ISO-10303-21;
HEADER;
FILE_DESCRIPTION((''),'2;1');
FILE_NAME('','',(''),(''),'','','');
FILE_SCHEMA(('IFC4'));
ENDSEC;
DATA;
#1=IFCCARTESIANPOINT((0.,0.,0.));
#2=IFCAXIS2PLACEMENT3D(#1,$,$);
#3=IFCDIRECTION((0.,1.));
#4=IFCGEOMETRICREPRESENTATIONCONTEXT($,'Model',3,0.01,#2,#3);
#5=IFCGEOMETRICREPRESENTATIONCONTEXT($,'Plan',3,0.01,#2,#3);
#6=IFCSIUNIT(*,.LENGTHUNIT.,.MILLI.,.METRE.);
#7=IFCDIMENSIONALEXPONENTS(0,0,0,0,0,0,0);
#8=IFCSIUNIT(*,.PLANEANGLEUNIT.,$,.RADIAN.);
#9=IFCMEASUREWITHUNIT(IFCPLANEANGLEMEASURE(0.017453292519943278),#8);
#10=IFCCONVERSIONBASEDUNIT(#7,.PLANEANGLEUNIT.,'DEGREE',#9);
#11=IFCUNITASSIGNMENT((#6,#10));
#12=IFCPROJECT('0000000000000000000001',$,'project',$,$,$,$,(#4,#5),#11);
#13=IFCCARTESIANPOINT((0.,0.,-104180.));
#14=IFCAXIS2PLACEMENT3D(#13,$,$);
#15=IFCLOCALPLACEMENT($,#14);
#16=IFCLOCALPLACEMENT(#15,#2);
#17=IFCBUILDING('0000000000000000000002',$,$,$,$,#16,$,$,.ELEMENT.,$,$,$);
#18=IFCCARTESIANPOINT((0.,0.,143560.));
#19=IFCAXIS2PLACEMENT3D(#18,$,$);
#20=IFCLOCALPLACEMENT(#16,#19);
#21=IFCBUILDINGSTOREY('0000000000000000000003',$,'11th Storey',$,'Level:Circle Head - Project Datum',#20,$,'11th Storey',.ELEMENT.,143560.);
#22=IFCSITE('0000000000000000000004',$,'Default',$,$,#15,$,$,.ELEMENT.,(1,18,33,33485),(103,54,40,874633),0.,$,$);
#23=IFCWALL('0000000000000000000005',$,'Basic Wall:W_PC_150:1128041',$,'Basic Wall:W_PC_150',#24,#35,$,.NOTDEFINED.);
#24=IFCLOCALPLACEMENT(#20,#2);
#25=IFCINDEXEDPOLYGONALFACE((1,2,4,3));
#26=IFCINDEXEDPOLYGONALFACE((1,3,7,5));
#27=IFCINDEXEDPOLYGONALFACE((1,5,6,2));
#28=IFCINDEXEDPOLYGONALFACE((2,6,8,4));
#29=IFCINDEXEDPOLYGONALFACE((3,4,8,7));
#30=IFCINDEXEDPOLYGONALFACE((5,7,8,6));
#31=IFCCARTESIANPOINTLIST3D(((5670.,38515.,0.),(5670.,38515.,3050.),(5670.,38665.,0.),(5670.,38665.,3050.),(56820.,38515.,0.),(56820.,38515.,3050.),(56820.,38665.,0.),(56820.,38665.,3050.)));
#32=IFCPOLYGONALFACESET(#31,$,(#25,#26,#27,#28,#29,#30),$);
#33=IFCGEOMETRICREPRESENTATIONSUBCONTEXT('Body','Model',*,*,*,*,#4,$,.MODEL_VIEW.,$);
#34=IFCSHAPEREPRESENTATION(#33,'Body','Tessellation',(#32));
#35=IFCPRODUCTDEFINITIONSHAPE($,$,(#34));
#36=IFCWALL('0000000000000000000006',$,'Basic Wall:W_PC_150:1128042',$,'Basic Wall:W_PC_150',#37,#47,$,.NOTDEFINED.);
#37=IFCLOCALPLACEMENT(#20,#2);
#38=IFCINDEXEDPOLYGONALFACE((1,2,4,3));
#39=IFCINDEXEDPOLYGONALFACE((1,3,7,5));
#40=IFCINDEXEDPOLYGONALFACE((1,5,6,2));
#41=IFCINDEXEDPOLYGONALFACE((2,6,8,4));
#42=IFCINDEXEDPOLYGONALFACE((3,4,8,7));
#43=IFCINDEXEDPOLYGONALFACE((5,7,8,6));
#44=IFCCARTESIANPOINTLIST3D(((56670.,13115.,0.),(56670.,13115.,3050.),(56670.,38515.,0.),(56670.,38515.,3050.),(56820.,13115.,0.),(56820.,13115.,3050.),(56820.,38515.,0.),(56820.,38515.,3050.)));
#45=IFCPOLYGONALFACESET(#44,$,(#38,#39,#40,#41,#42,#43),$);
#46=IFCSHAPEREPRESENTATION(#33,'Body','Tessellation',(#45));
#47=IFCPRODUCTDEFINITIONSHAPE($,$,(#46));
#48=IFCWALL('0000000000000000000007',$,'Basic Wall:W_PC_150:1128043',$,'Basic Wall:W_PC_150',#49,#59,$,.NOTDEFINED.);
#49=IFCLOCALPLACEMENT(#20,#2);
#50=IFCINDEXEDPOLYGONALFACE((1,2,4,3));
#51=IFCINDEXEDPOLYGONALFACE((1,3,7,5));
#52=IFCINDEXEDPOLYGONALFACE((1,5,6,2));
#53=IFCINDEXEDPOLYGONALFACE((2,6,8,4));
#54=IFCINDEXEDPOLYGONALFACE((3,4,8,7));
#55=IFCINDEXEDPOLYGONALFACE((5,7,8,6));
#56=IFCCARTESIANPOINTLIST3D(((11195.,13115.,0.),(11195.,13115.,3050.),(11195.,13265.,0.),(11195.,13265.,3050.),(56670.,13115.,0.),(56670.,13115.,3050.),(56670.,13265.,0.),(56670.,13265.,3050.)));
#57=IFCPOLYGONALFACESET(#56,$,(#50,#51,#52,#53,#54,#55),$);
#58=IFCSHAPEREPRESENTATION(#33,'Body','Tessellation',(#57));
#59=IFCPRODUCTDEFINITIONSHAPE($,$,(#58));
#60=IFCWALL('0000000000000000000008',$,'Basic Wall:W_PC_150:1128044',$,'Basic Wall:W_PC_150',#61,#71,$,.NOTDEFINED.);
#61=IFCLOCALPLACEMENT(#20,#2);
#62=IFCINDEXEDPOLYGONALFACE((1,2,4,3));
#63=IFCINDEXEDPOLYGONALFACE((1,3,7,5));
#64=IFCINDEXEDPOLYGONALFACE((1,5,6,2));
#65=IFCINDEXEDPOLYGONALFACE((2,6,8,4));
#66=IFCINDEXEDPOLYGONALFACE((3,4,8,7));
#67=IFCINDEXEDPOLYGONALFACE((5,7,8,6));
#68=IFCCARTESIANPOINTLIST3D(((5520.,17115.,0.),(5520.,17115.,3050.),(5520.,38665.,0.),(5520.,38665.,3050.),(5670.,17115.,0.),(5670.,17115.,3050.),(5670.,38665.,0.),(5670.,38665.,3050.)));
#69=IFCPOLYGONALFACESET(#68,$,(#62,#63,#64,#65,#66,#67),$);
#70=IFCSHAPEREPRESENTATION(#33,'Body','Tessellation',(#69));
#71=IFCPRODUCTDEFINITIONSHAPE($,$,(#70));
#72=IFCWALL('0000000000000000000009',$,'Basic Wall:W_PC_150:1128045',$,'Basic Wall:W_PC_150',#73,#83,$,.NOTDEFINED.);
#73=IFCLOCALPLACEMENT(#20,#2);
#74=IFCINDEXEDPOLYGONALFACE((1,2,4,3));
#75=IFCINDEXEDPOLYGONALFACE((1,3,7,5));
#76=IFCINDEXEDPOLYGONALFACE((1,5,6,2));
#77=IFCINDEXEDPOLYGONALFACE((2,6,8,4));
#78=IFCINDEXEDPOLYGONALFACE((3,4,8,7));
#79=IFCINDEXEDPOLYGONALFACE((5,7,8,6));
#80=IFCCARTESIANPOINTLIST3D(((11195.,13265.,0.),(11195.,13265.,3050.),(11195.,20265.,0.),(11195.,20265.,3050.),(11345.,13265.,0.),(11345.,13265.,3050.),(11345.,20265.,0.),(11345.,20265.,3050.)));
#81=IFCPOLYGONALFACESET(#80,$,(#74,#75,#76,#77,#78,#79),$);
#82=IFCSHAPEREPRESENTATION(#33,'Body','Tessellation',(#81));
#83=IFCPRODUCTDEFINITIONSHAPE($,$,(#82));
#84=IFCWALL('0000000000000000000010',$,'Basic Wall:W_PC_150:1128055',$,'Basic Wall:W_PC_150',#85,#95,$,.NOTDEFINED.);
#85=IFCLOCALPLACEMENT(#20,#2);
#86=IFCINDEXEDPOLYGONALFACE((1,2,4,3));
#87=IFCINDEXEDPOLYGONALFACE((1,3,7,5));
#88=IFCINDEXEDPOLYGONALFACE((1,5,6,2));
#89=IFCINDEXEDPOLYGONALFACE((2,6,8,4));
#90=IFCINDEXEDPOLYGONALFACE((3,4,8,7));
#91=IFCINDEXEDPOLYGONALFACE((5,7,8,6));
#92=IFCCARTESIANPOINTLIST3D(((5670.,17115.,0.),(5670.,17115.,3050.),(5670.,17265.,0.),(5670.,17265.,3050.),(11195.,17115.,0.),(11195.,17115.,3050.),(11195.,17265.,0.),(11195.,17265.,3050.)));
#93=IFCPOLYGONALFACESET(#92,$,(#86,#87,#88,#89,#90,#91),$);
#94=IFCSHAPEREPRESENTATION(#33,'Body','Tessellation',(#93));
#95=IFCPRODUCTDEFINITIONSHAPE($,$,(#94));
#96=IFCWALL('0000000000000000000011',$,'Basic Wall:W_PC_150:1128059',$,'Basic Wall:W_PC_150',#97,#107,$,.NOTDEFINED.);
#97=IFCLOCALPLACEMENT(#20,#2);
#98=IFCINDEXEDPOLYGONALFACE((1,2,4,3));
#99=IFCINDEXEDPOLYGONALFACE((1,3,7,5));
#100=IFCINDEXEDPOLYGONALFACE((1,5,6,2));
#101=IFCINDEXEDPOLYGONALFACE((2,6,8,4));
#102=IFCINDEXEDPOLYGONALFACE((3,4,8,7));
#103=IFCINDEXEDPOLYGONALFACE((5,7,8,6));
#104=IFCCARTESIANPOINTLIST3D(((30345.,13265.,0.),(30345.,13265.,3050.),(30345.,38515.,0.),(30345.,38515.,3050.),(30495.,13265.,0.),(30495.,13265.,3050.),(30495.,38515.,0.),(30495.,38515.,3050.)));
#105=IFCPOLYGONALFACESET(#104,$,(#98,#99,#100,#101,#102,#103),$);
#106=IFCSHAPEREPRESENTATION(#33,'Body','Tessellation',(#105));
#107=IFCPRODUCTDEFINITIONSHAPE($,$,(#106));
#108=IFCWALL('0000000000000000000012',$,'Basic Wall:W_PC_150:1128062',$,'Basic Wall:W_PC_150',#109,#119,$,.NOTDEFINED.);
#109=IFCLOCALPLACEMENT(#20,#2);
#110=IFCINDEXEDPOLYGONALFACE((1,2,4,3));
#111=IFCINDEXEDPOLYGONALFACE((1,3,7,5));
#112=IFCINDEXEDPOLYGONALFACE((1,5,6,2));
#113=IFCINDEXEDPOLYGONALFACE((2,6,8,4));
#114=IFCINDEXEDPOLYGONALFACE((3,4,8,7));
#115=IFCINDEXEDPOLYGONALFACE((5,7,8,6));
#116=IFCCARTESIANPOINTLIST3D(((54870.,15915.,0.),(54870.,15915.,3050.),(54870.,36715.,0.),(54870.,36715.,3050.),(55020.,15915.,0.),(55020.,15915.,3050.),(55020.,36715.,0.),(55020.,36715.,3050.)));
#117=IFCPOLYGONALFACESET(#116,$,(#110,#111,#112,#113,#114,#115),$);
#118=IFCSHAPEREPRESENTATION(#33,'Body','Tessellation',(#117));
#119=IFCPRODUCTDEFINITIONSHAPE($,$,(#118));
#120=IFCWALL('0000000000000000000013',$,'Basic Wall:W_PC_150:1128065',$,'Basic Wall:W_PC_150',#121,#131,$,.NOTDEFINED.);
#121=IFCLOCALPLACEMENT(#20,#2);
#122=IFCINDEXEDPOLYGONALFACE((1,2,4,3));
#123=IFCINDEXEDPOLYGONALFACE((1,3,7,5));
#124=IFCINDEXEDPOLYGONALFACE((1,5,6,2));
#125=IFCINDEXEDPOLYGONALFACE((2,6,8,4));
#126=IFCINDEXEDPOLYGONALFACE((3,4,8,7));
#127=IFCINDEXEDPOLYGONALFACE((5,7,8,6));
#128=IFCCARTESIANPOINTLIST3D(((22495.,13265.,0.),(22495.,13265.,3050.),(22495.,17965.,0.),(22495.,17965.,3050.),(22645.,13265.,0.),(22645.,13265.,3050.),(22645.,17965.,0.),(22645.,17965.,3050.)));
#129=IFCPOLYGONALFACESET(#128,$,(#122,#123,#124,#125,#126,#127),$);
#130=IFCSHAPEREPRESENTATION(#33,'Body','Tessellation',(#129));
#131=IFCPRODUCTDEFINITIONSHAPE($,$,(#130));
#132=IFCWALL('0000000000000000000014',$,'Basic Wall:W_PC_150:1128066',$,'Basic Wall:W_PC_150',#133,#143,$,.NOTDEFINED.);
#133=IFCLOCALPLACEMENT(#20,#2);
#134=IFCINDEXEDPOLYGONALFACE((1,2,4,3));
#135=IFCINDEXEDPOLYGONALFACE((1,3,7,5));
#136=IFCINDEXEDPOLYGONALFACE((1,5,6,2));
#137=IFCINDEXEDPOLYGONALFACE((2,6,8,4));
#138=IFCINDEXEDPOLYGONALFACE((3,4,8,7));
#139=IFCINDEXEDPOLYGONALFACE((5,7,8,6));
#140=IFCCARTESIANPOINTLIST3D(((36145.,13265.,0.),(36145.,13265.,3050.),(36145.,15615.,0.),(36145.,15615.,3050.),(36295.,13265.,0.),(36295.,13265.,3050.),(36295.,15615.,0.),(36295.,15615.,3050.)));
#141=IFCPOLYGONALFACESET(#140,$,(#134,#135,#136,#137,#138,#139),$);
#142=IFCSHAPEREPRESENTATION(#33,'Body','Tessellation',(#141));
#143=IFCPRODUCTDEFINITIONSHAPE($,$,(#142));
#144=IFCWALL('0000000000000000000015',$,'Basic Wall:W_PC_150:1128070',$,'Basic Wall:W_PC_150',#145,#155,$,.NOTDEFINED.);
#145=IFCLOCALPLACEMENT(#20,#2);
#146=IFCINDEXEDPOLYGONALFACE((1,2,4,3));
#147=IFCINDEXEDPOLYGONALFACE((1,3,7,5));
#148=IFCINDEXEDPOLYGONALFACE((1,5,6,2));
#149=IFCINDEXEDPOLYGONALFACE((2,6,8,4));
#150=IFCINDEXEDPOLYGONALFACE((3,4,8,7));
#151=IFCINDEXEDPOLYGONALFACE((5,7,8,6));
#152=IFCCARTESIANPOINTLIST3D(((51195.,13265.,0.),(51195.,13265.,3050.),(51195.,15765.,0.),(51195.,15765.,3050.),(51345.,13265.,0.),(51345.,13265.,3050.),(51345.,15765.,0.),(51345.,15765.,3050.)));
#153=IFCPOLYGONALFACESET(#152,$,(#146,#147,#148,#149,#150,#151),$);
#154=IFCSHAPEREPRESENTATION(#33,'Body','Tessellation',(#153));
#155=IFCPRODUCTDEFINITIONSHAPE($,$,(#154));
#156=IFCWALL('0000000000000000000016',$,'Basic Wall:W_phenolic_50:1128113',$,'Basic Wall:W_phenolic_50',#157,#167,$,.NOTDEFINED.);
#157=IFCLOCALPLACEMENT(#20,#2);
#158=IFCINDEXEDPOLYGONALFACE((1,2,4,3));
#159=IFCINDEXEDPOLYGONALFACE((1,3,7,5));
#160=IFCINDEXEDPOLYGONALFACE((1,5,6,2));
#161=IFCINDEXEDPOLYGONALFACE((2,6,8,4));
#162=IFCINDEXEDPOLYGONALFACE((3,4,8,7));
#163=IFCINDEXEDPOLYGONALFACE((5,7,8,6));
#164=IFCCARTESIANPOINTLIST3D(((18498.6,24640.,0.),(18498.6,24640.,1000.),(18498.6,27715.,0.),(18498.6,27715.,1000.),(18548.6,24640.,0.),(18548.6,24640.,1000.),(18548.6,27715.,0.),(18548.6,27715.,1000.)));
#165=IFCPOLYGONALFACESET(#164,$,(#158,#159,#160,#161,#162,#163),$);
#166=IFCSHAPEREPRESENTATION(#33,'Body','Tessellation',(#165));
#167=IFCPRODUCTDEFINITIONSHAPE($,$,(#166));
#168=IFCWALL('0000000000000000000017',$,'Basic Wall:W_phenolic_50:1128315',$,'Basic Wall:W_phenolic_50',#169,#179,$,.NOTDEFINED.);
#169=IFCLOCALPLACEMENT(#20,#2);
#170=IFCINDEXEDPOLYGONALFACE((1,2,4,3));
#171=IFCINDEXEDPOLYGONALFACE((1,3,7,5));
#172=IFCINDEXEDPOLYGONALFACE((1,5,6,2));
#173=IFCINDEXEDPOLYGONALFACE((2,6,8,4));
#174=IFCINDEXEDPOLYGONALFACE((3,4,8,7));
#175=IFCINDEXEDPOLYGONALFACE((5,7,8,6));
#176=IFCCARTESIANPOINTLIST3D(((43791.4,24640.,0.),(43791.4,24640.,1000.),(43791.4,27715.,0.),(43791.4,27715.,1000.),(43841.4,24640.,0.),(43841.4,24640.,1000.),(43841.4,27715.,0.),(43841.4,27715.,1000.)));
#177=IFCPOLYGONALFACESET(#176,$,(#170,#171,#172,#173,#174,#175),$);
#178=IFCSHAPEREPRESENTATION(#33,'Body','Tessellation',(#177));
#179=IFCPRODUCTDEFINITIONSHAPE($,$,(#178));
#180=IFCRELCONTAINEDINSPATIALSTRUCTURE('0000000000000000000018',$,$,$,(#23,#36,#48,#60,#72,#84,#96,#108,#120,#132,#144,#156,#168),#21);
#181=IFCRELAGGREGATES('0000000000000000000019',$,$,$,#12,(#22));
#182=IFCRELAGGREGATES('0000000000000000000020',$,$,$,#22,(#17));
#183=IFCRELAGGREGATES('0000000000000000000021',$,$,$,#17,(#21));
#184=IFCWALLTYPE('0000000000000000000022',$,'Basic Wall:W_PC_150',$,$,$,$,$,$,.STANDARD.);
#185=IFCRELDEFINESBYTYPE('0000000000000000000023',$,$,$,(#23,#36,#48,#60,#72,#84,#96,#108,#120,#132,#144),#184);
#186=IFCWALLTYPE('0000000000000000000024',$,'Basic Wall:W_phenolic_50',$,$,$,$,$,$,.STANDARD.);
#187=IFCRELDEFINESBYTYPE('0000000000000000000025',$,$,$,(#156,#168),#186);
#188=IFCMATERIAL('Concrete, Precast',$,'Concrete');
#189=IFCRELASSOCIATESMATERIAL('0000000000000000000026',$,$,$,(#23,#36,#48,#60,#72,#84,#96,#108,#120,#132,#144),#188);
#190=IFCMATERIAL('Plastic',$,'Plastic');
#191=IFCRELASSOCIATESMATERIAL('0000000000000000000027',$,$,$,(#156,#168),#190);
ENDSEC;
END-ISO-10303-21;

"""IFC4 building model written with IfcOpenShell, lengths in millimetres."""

from ifc_helpers import new_model, entity, si_unit, converted_unit, direction, frame, origin, place, context, subcontext, project, spatial, indexed_curve, outline, extrude, material, type_object, element, save


model = new_model("IFC4")

# Units and contexts
model_context = context("Model", 3, precision=0.01, world=origin(), true_north=direction((0.0, 1.0)))
plan_context = context("Plan", 3, precision=0.01, world=origin(), true_north=direction((0.0, 1.0)))
body_context = subcontext(model_context, "Body", "Model", "MODEL_VIEW")
ifc_project = project(units=[si_unit("LENGTHUNIT", "METRE", prefix="MILLI"), converted_unit("PLANEANGLEUNIT", "DEGREE", entity("IfcPlaneAngleMeasure", 0.017453292519943278), si_unit("PLANEANGLEUNIT", "RADIAN"), dimensions=[0, 0, 0, 0, 0, 0, 0])], contexts=[model_context, plan_context])

# Site, building, storey
site_placement = place(None, frame((0.0, 0.0, -104180.0)))
site = spatial("IfcSite", under=ifc_project, at=site_placement, Name="Default", CompositionType="ELEMENT", RefLatitude=(1, 18, 33, 33485), RefLongitude=(103, 54, 40, 874633), RefElevation=0.0)
building_placement = place(site_placement, origin())
building = spatial("IfcBuilding", under=site, at=building_placement, CompositionType="ELEMENT")
storey_placement = place(building_placement, frame((0.0, 0.0, 143560.0)))
storey = spatial("IfcBuildingStorey", under=building, at=storey_placement, Name="11th Storey", ObjectType="Level:Circle Head - Project Datum", LongName="11th Storey", CompositionType="ELEMENT", Elevation=143560.0)

# Shared definitions
ifc_material_1 = material(Name="Concrete, Precast", Category="Concrete")

# Walls
wall_type_1 = type_object("IfcWallType", Name="Basic Wall:W_PC_150", PredefinedType="STANDARD")
wall_1_placement = place(storey_placement, frame((56820.0, 38590.0, 0.0), z_axis=(0.0, 0.0, 1.0), x_axis=(-1.0, 0.0, 0.0)))
element("IfcWall", 1, at=wall_1_placement, inside=storey, type_object=wall_type_1, material=ifc_material_1, Name="Basic Wall:W_PC_150:1128041", ObjectType="Basic Wall:W_PC_150", PredefinedType="NOTDEFINED", context=body_context, shape_type="SweptSolid", body=[
    extrude(outline(indexed_curve([(51150.0, 75.0), (0.0, 75.0), (0.0, -75.0), (51150.0, -75.0), (51150.0, 75.0)], self_intersect=False)), origin(), (0.0, 0.0, 1.0), 3050.0),
])
wall_2_placement = place(storey_placement, frame((56745.0, 13115.0, 0.0), z_axis=(0.0, 0.0, 1.0), x_axis=(0.0, 1.0, 0.0)))
element("IfcWall", 2, at=wall_2_placement, inside=storey, type_object=wall_type_1, material=ifc_material_1, Name="Basic Wall:W_PC_150:1128042", ObjectType="Basic Wall:W_PC_150", PredefinedType="NOTDEFINED", context=body_context, shape_type="SweptSolid", body=[
    extrude(outline(indexed_curve([(25400.0, 75.0), (0.0, 75.0), (0.0, -75.0), (25400.0, -75.0), (25400.0, 75.0)], self_intersect=False)), origin(), (0.0, 0.0, 1.0), 3050.0),
])
wall_3_placement = place(storey_placement, frame((11195.0, 13190.0, 0.0)))
element("IfcWall", 3, at=wall_3_placement, inside=storey, type_object=wall_type_1, material=ifc_material_1, Name="Basic Wall:W_PC_150:1128043", ObjectType="Basic Wall:W_PC_150", PredefinedType="NOTDEFINED", context=body_context, shape_type="SweptSolid", body=[
    extrude(outline(indexed_curve([(45475.0, 75.0), (0.0, 75.0), (0.0, -75.0), (45475.0, -75.0), (45475.0, 75.0)], self_intersect=False)), origin(), (0.0, 0.0, 1.0), 3050.0),
])
wall_4_placement = place(storey_placement, frame((5595.0, 38665.0, 0.0), z_axis=(0.0, 0.0, 1.0), x_axis=(0.0, -1.0, 0.0)))
element("IfcWall", 4, at=wall_4_placement, inside=storey, type_object=wall_type_1, material=ifc_material_1, Name="Basic Wall:W_PC_150:1128044", ObjectType="Basic Wall:W_PC_150", PredefinedType="NOTDEFINED", context=body_context, shape_type="SweptSolid", body=[
    extrude(outline(indexed_curve([(21550.0, 75.0), (0.0, 75.0), (0.0, -75.0), (21550.0, -75.0), (21550.0, 75.0)], self_intersect=False)), origin(), (0.0, 0.0, 1.0), 3050.0),
])
wall_5_placement = place(storey_placement, frame((11270.0, 20265.0, 0.0), z_axis=(0.0, 0.0, 1.0), x_axis=(0.0, -1.0, 0.0)))
element("IfcWall", 5, at=wall_5_placement, inside=storey, type_object=wall_type_1, material=ifc_material_1, Name="Basic Wall:W_PC_150:1128045", ObjectType="Basic Wall:W_PC_150", PredefinedType="NOTDEFINED", context=body_context, shape_type="SweptSolid", body=[
    extrude(outline(indexed_curve([(7000.0, 75.0), (0.0, 75.0), (0.0, -75.0), (7000.0, -75.0), (7000.0, 75.0)], self_intersect=False)), origin(), (0.0, 0.0, 1.0), 3050.0),
])
wall_6_placement = place(storey_placement, frame((5670.0, 17190.0, 0.0)))
element("IfcWall", 6, at=wall_6_placement, inside=storey, type_object=wall_type_1, material=ifc_material_1, Name="Basic Wall:W_PC_150:1128055", ObjectType="Basic Wall:W_PC_150", PredefinedType="NOTDEFINED", context=body_context, shape_type="SweptSolid", body=[
    extrude(outline(indexed_curve([(5525.0, 75.0), (0.0, 75.0), (0.0, -75.0), (5525.0, -75.0), (5525.0, 75.0)], self_intersect=False)), origin(), (0.0, 0.0, 1.0), 3050.0),
])
wall_7_placement = place(storey_placement, frame((30420.0, 13265.0, 0.0), z_axis=(0.0, 0.0, 1.0), x_axis=(0.0, 1.0, 0.0)))
element("IfcWall", 7, at=wall_7_placement, inside=storey, type_object=wall_type_1, material=ifc_material_1, Name="Basic Wall:W_PC_150:1128059", ObjectType="Basic Wall:W_PC_150", PredefinedType="NOTDEFINED", context=body_context, shape_type="SweptSolid", body=[
    extrude(outline(indexed_curve([(25250.0, 75.0), (0.0, 75.0), (0.0, -75.0), (25250.0, -75.0), (25250.0, 75.0)], self_intersect=False)), origin(), (0.0, 0.0, 1.0), 3050.0),
])
wall_8_placement = place(storey_placement, frame((54945.0, 15915.0, 0.0), z_axis=(0.0, 0.0, 1.0), x_axis=(0.0, 1.0, 0.0)))
element("IfcWall", 8, at=wall_8_placement, inside=storey, type_object=wall_type_1, material=ifc_material_1, Name="Basic Wall:W_PC_150:1128062", ObjectType="Basic Wall:W_PC_150", PredefinedType="NOTDEFINED", context=body_context, shape_type="SweptSolid", body=[
    extrude(outline(indexed_curve([(20800.0, 75.0), (0.0, 75.0), (0.0, -75.0), (20800.0, -75.0), (20800.0, 75.0)], self_intersect=False)), origin(), (0.0, 0.0, 1.0), 3050.0),
])
wall_9_placement = place(storey_placement, frame((22570.0, 13265.0, 0.0), z_axis=(0.0, 0.0, 1.0), x_axis=(0.0, 1.0, 0.0)))
element("IfcWall", 9, at=wall_9_placement, inside=storey, type_object=wall_type_1, material=ifc_material_1, Name="Basic Wall:W_PC_150:1128065", ObjectType="Basic Wall:W_PC_150", PredefinedType="NOTDEFINED", context=body_context, shape_type="SweptSolid", body=[
    extrude(outline(indexed_curve([(4700.0, 75.0), (0.0, 75.0), (0.0, -75.0), (4700.0, -75.0), (4700.0, 75.0)], self_intersect=False)), origin(), (0.0, 0.0, 1.0), 3050.0),
])
wall_10_placement = place(storey_placement, frame((36220.0, 13265.0, 0.0), z_axis=(0.0, 0.0, 1.0), x_axis=(0.0, 1.0, 0.0)))
element("IfcWall", 10, at=wall_10_placement, inside=storey, type_object=wall_type_1, material=ifc_material_1, Name="Basic Wall:W_PC_150:1128066", ObjectType="Basic Wall:W_PC_150", PredefinedType="NOTDEFINED", context=body_context, shape_type="SweptSolid", body=[
    extrude(outline(indexed_curve([(2350.0, 75.0), (0.0, 75.0), (0.0, -75.0), (2350.0, -75.0), (2350.0, 75.0)], self_intersect=False)), origin(), (0.0, 0.0, 1.0), 3050.0),
])
wall_11_placement = place(storey_placement, frame((51270.0, 13265.0, 0.0), z_axis=(0.0, 0.0, 1.0), x_axis=(0.0, 1.0, 0.0)))
element("IfcWall", 11, at=wall_11_placement, inside=storey, type_object=wall_type_1, material=ifc_material_1, Name="Basic Wall:W_PC_150:1128070", ObjectType="Basic Wall:W_PC_150", PredefinedType="NOTDEFINED", context=body_context, shape_type="SweptSolid", body=[
    extrude(outline(indexed_curve([(2500.0, 75.0), (0.0, 75.0), (0.0, -75.0), (2500.0, -75.0), (2500.0, 75.0)], self_intersect=False)), origin(), (0.0, 0.0, 1.0), 3050.0),
])
ifc_material_2 = material(Name="Plastic", Category="Plastic")
wall_type_2 = type_object("IfcWallType", Name="Basic Wall:W_phenolic_50", PredefinedType="STANDARD")
wall_12_placement = place(storey_placement, frame((18523.6, 24640.0, 0.0), z_axis=(0.0, 0.0, 1.0), x_axis=(0.0, 1.0, 0.0)))
element("IfcWall", 12, at=wall_12_placement, inside=storey, type_object=wall_type_2, material=ifc_material_2, Name="Basic Wall:W_phenolic_50:1128113", ObjectType="Basic Wall:W_phenolic_50", PredefinedType="NOTDEFINED", context=body_context, shape_type="SweptSolid", body=[
    extrude(outline(indexed_curve([(3075.0, 25.0), (0.0, 25.0), (0.0, -25.0), (3075.0, -25.0), (3075.0, 25.0)], self_intersect=False)), origin(), (0.0, 0.0, 1.0), 1000.0),
])
wall_13_placement = place(storey_placement, frame((43816.4, 24640.0, 0.0), z_axis=(0.0, 0.0, 1.0), x_axis=(0.0, 1.0, 0.0)))
element("IfcWall", 13, at=wall_13_placement, inside=storey, type_object=wall_type_2, material=ifc_material_2, Name="Basic Wall:W_phenolic_50:1128315", ObjectType="Basic Wall:W_phenolic_50", PredefinedType="NOTDEFINED", context=body_context, shape_type="SweptSolid", body=[
    extrude(outline(indexed_curve([(3075.0, 25.0), (0.0, 25.0), (0.0, -25.0), (3075.0, -25.0), (3075.0, 25.0)], self_intersect=False)), origin(), (0.0, 0.0, 1.0), 1000.0),
])

save(model, "model.ifc")
